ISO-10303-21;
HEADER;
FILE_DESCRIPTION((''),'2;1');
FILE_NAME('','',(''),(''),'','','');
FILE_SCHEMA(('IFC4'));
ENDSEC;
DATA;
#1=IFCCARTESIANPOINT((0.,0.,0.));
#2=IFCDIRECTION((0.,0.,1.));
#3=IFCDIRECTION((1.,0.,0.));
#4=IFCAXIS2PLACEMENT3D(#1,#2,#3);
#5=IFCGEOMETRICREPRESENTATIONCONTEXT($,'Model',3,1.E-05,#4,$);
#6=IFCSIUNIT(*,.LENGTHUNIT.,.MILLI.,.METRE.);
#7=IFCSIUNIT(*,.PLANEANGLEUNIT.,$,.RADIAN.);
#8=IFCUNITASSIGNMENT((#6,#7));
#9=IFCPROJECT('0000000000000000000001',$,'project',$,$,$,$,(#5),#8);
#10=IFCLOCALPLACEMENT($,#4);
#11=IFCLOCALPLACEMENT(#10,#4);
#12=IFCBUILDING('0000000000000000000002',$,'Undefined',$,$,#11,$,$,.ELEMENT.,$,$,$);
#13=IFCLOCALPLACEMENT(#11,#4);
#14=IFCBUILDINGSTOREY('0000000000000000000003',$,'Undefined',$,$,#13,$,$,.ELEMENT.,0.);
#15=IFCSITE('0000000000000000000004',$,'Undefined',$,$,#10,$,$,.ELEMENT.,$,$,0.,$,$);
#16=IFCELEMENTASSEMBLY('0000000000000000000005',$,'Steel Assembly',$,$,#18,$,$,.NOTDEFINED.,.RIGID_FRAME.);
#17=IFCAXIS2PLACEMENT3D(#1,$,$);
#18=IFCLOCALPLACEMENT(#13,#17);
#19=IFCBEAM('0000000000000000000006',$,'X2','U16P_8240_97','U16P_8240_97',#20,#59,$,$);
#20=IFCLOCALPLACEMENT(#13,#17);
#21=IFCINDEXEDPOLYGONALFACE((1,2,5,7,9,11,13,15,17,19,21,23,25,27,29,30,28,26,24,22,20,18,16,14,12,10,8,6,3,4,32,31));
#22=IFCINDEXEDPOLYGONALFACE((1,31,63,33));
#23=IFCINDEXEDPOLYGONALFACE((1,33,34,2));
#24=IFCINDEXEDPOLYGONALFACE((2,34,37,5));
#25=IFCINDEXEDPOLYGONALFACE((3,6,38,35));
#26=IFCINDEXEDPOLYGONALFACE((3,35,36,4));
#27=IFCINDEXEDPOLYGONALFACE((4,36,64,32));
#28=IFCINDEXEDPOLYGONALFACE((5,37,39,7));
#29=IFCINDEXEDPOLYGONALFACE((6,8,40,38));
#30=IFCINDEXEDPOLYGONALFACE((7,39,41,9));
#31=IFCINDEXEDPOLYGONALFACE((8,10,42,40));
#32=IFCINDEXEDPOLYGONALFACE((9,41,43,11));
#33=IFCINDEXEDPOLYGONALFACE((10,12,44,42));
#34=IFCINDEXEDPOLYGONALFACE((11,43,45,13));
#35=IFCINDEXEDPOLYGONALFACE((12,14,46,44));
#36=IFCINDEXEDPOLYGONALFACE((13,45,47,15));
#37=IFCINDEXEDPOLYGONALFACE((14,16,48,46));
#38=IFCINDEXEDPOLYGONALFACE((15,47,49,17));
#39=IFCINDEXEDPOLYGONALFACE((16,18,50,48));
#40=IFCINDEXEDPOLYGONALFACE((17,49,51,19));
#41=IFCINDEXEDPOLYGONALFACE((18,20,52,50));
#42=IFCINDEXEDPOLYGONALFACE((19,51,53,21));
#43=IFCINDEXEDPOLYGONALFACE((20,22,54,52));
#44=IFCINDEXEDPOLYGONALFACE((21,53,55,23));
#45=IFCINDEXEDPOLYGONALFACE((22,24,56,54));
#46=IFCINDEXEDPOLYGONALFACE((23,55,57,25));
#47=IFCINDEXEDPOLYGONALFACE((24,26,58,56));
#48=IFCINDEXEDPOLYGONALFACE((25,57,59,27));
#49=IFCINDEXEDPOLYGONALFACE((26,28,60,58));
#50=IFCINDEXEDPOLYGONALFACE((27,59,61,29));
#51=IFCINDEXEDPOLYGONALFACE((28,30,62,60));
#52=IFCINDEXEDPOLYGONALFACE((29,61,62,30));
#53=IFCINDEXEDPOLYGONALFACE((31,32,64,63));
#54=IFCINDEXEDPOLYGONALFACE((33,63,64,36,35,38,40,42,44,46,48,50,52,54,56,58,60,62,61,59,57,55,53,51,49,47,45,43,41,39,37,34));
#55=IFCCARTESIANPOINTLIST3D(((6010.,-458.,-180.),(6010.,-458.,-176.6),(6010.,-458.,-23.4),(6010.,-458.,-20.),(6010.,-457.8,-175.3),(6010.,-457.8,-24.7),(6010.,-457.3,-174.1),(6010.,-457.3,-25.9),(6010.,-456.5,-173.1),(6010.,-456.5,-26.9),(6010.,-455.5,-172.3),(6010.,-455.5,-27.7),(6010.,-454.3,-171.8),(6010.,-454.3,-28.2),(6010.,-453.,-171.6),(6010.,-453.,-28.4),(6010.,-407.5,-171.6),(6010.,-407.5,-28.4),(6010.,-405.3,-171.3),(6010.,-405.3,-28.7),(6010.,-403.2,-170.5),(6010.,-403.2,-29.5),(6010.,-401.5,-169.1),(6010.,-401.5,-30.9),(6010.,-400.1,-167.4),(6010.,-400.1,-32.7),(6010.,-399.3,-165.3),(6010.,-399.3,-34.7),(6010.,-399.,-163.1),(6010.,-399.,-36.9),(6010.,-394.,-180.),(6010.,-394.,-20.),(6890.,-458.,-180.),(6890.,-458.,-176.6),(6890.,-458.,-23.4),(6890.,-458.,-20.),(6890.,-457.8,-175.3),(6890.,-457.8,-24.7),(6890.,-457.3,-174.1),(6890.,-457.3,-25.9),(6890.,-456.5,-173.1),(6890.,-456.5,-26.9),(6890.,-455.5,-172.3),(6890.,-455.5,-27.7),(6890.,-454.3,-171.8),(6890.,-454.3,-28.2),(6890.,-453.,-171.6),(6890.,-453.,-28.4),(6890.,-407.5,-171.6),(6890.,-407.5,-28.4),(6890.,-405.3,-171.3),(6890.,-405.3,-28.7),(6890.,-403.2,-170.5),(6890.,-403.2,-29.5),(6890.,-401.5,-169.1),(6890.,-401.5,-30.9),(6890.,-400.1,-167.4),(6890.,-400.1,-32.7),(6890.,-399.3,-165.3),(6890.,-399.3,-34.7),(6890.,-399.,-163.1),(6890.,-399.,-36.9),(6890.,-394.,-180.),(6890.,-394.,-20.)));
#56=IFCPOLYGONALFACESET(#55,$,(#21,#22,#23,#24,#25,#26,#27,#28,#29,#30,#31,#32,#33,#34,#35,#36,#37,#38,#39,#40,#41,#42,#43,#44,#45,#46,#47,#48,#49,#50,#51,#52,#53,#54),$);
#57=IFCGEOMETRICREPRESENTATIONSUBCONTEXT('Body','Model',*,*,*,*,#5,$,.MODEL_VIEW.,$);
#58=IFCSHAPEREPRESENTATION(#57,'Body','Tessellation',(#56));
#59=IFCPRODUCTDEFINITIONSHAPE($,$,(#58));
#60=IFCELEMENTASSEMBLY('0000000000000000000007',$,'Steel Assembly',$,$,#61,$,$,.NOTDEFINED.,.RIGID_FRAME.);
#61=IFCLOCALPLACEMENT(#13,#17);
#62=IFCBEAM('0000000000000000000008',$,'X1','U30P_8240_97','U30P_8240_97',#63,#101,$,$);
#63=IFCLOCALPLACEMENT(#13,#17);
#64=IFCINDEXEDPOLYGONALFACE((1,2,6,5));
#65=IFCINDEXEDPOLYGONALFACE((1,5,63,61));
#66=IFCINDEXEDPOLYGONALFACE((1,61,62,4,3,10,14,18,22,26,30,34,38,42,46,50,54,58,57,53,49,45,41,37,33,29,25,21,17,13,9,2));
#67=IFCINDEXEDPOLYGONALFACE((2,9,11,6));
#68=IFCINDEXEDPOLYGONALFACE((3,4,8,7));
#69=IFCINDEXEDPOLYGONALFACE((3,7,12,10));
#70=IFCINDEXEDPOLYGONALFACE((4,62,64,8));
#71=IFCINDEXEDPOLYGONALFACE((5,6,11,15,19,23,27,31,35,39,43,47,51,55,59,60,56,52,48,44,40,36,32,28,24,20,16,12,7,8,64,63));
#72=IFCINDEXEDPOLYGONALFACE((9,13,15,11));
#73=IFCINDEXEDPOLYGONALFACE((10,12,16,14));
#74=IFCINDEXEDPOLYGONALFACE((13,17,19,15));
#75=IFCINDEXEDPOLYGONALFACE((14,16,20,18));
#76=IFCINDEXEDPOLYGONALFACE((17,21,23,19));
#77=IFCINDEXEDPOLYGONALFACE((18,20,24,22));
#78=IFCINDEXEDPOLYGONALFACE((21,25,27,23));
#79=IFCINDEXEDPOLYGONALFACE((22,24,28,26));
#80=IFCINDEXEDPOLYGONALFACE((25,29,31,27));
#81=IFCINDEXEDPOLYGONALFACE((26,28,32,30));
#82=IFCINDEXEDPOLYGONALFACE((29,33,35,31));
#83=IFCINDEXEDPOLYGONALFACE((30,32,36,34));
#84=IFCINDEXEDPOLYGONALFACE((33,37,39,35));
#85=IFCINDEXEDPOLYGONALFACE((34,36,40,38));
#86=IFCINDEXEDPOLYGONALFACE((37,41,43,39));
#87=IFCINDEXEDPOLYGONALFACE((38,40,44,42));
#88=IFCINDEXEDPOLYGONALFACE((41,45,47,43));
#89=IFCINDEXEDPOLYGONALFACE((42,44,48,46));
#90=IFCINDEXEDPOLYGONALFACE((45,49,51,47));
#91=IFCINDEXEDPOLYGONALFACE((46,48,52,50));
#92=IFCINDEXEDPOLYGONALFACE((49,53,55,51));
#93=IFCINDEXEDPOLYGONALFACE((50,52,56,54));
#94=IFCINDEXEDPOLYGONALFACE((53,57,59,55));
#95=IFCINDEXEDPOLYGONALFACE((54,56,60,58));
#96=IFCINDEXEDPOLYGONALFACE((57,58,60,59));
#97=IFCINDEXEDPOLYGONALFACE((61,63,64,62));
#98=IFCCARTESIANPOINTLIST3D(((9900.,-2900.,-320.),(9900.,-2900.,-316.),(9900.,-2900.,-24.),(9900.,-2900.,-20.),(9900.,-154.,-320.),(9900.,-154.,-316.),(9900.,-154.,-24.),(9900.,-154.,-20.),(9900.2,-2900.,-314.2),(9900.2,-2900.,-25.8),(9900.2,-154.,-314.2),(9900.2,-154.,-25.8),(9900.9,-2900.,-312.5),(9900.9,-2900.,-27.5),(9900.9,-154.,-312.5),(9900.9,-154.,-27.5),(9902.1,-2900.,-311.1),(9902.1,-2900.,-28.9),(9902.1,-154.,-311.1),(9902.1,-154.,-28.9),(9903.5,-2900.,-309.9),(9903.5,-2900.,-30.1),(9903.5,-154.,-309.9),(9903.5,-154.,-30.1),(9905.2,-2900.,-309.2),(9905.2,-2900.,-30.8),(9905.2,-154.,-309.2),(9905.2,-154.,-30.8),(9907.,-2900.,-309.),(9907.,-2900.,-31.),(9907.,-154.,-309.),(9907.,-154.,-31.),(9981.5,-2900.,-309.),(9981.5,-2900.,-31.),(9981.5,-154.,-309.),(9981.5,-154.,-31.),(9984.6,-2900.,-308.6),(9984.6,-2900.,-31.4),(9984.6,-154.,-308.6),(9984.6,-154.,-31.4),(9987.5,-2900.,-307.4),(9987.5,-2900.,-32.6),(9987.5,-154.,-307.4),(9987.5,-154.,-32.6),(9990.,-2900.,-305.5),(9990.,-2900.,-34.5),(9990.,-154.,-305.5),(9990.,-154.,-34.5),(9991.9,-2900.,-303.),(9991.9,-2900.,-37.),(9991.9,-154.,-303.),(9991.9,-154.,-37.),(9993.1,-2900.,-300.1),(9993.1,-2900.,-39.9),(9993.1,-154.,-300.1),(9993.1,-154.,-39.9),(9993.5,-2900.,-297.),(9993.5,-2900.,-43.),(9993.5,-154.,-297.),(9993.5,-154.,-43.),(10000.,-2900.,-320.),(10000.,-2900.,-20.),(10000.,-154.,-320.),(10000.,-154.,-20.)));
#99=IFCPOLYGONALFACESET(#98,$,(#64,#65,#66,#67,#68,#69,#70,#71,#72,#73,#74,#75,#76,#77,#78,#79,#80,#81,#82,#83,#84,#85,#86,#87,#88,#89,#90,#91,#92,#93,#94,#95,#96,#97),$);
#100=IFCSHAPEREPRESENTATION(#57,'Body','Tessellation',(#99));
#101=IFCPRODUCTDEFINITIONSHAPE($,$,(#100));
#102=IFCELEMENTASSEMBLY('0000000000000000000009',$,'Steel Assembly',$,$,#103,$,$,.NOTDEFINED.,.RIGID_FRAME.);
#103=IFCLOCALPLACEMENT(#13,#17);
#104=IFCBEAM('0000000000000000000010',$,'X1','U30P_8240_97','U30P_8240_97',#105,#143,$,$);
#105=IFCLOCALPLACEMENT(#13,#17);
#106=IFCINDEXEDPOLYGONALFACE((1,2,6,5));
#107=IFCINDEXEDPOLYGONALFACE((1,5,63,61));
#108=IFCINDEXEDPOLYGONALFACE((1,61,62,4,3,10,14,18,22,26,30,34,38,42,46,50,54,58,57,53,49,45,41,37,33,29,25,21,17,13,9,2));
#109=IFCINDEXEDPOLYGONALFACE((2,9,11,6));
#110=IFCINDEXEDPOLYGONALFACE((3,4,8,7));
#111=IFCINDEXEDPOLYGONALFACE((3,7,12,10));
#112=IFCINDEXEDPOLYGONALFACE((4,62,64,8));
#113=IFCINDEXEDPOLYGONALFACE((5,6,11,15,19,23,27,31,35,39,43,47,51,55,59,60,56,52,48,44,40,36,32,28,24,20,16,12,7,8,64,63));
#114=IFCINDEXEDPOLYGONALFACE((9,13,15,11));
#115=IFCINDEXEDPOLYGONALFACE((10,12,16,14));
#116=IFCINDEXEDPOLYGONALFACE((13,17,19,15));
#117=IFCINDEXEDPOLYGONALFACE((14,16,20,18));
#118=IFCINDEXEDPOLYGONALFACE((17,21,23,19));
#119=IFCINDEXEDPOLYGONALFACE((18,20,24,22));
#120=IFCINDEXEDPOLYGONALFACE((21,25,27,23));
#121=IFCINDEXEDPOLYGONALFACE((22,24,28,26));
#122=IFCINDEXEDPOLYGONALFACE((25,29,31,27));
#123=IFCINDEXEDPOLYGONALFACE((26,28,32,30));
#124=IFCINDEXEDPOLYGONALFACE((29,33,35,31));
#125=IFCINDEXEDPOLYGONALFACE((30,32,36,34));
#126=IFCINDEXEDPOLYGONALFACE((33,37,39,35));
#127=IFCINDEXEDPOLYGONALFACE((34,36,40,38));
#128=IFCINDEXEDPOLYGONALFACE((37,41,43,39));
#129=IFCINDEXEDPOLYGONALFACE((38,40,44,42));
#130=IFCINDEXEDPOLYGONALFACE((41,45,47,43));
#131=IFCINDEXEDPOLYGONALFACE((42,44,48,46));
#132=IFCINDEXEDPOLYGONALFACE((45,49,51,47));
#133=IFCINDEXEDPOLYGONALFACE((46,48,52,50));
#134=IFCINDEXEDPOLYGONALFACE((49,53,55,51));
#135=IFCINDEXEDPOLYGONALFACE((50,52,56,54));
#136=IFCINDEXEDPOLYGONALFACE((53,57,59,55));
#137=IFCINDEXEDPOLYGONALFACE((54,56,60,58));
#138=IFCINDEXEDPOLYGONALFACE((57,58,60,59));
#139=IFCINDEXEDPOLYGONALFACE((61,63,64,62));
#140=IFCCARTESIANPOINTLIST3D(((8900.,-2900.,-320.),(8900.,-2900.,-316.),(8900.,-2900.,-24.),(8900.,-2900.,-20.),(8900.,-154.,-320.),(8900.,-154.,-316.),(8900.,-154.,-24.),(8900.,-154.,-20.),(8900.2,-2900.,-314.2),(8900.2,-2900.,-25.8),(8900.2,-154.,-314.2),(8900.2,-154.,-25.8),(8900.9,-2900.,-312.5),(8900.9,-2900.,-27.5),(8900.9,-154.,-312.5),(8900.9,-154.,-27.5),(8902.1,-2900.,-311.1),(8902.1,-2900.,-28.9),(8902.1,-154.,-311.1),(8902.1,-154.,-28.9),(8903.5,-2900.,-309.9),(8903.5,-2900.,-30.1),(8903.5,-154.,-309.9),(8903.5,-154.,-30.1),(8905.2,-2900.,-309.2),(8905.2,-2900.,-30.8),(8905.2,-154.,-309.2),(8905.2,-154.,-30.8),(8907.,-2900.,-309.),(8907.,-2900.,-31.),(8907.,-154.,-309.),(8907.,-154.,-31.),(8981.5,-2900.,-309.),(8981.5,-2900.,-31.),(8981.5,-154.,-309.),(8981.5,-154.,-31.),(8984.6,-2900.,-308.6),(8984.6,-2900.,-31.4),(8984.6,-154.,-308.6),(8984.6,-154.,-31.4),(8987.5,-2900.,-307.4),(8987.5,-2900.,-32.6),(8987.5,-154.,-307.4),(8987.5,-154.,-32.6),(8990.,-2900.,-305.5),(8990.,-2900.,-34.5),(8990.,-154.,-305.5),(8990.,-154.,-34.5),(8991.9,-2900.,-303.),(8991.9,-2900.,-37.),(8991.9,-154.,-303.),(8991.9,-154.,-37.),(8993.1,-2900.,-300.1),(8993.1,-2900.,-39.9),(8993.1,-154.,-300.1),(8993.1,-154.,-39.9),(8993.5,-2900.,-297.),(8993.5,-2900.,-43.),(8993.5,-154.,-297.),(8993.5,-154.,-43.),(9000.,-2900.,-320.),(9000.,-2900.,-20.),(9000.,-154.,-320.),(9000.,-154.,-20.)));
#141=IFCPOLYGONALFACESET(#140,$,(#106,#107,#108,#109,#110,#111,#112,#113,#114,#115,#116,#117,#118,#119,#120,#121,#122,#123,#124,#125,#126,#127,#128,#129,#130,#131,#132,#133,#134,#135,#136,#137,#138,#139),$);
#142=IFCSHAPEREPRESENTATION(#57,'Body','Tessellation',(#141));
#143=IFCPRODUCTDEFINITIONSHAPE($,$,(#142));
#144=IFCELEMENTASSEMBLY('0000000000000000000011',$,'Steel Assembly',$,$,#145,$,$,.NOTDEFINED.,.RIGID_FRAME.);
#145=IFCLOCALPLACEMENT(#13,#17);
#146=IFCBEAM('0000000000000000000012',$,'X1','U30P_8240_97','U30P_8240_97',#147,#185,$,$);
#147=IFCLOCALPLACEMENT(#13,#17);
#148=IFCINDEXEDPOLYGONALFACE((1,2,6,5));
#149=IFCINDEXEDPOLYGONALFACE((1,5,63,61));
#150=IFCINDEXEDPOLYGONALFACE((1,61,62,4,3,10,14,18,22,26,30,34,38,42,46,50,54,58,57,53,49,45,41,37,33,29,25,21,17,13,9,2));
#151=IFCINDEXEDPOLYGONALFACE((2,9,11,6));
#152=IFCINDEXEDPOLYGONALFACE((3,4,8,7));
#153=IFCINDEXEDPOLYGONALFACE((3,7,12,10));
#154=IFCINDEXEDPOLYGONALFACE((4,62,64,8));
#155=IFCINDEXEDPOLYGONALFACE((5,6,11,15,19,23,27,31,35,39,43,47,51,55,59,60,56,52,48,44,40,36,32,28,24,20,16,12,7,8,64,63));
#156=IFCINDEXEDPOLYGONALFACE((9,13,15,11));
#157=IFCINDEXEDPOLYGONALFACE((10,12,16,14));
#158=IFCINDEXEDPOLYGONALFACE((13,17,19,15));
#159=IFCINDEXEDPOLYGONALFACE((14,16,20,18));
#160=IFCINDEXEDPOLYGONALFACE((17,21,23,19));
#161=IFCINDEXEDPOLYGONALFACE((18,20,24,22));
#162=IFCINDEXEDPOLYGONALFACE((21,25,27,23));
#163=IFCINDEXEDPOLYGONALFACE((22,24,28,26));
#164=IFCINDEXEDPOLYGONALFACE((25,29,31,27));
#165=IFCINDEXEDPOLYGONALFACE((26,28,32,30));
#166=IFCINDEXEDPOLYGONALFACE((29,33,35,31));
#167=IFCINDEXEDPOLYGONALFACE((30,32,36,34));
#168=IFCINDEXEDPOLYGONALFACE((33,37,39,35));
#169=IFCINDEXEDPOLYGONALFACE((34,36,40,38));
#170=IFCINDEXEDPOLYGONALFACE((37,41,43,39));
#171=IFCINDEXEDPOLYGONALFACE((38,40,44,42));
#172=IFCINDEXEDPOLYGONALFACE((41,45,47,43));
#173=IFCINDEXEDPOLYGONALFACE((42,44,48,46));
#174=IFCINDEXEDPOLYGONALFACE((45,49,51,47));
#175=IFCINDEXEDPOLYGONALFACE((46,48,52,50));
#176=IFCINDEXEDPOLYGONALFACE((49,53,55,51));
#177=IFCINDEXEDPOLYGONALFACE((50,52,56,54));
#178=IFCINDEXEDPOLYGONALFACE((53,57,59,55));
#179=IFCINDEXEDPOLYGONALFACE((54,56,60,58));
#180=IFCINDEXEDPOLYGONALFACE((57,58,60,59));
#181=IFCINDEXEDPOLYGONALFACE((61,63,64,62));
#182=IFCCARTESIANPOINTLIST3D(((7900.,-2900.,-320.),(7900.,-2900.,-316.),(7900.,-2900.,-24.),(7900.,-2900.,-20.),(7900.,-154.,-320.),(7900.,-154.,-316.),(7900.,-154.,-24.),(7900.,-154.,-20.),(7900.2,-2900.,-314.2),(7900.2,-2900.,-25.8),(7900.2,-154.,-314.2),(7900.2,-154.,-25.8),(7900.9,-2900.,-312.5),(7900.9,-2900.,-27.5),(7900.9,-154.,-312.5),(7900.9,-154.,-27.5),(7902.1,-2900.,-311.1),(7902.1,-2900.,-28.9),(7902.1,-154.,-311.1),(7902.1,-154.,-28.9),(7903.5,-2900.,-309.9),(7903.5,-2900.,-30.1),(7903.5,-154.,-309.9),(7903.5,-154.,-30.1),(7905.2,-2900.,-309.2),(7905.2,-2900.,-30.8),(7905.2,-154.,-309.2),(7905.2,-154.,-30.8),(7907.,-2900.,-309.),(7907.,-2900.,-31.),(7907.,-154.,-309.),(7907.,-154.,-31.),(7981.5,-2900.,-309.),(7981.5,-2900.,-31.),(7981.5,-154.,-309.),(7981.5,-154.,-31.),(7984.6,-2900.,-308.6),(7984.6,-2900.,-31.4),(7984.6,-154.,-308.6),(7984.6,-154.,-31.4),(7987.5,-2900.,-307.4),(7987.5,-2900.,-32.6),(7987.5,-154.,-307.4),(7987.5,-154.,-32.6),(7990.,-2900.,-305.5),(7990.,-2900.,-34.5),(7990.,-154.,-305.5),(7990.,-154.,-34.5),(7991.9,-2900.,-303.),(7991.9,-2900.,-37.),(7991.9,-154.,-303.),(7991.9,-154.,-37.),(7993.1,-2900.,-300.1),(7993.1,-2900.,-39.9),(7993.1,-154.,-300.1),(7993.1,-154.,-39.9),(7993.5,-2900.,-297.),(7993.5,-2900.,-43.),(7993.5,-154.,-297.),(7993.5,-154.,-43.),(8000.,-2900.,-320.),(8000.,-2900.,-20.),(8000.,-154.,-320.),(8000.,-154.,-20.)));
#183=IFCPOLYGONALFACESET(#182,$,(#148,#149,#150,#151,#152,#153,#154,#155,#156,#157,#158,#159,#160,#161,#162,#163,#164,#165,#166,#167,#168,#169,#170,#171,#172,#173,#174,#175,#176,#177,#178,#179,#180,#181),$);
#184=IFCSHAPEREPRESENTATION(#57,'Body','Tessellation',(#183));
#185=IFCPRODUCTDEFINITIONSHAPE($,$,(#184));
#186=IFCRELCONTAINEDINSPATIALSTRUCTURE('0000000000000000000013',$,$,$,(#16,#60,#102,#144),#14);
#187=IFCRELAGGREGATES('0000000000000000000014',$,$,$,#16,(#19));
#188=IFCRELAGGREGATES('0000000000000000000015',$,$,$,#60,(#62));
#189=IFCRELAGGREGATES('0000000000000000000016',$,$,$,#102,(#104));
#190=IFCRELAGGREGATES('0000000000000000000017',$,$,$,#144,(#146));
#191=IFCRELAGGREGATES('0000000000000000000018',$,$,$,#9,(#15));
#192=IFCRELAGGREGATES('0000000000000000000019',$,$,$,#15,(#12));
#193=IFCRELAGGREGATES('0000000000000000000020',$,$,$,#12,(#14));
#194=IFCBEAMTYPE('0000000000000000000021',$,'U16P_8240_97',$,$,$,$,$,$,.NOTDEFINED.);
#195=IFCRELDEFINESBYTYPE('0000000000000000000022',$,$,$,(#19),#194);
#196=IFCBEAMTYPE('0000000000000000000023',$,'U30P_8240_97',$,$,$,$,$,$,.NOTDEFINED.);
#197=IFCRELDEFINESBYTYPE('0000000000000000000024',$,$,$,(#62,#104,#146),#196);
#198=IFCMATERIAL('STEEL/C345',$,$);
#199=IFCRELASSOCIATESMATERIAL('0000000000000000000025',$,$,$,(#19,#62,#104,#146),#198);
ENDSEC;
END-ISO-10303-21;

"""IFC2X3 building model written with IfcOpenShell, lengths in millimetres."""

from ifc_helpers import new_model, si_unit, frame, origin_with_axes, origin_2d_with_axis, place, context, subcontext, project, spatial, u_section, extrude, material, type_object, element, aggregate, save


model = new_model("IFC2X3")

# Units and contexts
model_context = context("Model", 3, precision=1e-05, world=origin_with_axes())
body_context = subcontext(model_context, "Body", "Model", "MODEL_VIEW")
ifc_project = project(units=[si_unit("LENGTHUNIT", "METRE", prefix="MILLI"), si_unit("PLANEANGLEUNIT", "RADIAN")], contexts=[model_context])

# Site, building, storey
site_placement = place(None, origin_with_axes())
site = spatial("IfcSite", under=ifc_project, at=site_placement, Name="Undefined", CompositionType="ELEMENT", RefElevation=0.0)
building_placement = place(site_placement, origin_with_axes())
building = spatial("IfcBuilding", under=site, at=building_placement, Name="Undefined", CompositionType="ELEMENT")
storey_placement = place(building_placement, origin_with_axes())
storey = spatial("IfcBuildingStorey", under=building, at=storey_placement, Name="Undefined", CompositionType="ELEMENT", Elevation=0.0)

# Shared definitions
ifc_material_1 = material(Name="STEEL/C345")

# Element assemblies, beams
beam_type_1 = type_object("IfcBeamType", Name="U16P_8240_97", PredefinedType="NOTDEFINED")
assembly_1_placement = place(storey_placement, origin_with_axes())
assembly_1 = element("IfcElementAssembly", 1, at=assembly_1_placement, inside=storey, Name="Steel Assembly", AssemblyPlace="NOTDEFINED", PredefinedType="RIGID_FRAME")
beam_1_placement = place(assembly_1_placement, frame((6890.0, -426.0, -100.0), z_axis=(0.0, 0.0, -1.0), x_axis=(-1.0, 0.0, 0.0)))
beam_1 = element("IfcBeam", 2, at=beam_1_placement, type_object=beam_type_1, material=ifc_material_1, Name="X2", Description="U16P_8240_97", ObjectType="U16P_8240_97", context=body_context, shape_type="SweptSolid", body=[
    extrude(u_section(Depth=160.0, FlangeWidth=64.0, WebThickness=5.0, FlangeThickness=8.4, FilletRadius=8.5, EdgeRadius=5.0, at=origin_2d_with_axis()), frame((880.0, 0.0, 0.0), z_axis=(-1.0, 0.0, 0.0), x_axis=(0.0, -1.0, 0.0)), (0.0, 0.0, 1.0), 880.0),
])
aggregate(assembly_1, [beam_1])
assembly_2_placement = place(storey_placement, origin_with_axes())
assembly_2 = element("IfcElementAssembly", 3, at=assembly_2_placement, inside=storey, Name="Steel Assembly", AssemblyPlace="NOTDEFINED", PredefinedType="RIGID_FRAME")
beam_type_2 = type_object("IfcBeamType", Name="U30P_8240_97", PredefinedType="NOTDEFINED")
beam_2_placement = place(assembly_2_placement, frame((9950.0, -154.0, -170.0), z_axis=(0.0, 0.0, 1.0), x_axis=(0.0, -1.0, 0.0)))
beam_2 = element("IfcBeam", 4, at=beam_2_placement, type_object=beam_type_2, material=ifc_material_1, Name="X1", Description="U30P_8240_97", ObjectType="U30P_8240_97", context=body_context, shape_type="SweptSolid", body=[
    extrude(u_section(Depth=300.0, FlangeWidth=100.0, WebThickness=6.5, FlangeThickness=11.0, FilletRadius=12.0, EdgeRadius=7.0, at=origin_2d_with_axis()), frame((2746.0, 0.0, 0.0), z_axis=(-1.0, 0.0, 0.0), x_axis=(0.0, -1.0, 0.0)), (0.0, 0.0, 1.0), 2746.0),
])
aggregate(assembly_2, [beam_2])
assembly_3_placement = place(storey_placement, origin_with_axes())
assembly_3 = element("IfcElementAssembly", 5, at=assembly_3_placement, inside=storey, Name="Steel Assembly", AssemblyPlace="NOTDEFINED", PredefinedType="RIGID_FRAME")
beam_3_placement = place(assembly_3_placement, frame((8950.0, -154.0, -170.0), z_axis=(0.0, 0.0, 1.0), x_axis=(0.0, -1.0, 0.0)))
beam_3 = element("IfcBeam", 6, at=beam_3_placement, type_object=beam_type_2, material=ifc_material_1, Name="X1", Description="U30P_8240_97", ObjectType="U30P_8240_97", context=body_context, shape_type="SweptSolid", body=[
    extrude(u_section(Depth=300.0, FlangeWidth=100.0, WebThickness=6.5, FlangeThickness=11.0, FilletRadius=12.0, EdgeRadius=7.0, at=origin_2d_with_axis()), frame((2746.0, 0.0, 0.0), z_axis=(-1.0, 0.0, 0.0), x_axis=(0.0, -1.0, 0.0)), (0.0, 0.0, 1.0), 2746.0),
])
aggregate(assembly_3, [beam_3])
assembly_4_placement = place(storey_placement, origin_with_axes())
assembly_4 = element("IfcElementAssembly", 7, at=assembly_4_placement, inside=storey, Name="Steel Assembly", AssemblyPlace="NOTDEFINED", PredefinedType="RIGID_FRAME")
beam_4_placement = place(assembly_4_placement, frame((7950.0, -154.0, -170.0), z_axis=(0.0, 0.0, 1.0), x_axis=(0.0, -1.0, 0.0)))
beam_4 = element("IfcBeam", 8, at=beam_4_placement, type_object=beam_type_2, material=ifc_material_1, Name="X1", Description="U30P_8240_97", ObjectType="U30P_8240_97", context=body_context, shape_type="SweptSolid", body=[
    extrude(u_section(Depth=300.0, FlangeWidth=100.0, WebThickness=6.5, FlangeThickness=11.0, FilletRadius=12.0, EdgeRadius=7.0, at=origin_2d_with_axis()), frame((2746.0, 0.0, 0.0), z_axis=(-1.0, 0.0, 0.0), x_axis=(0.0, -1.0, 0.0)), (0.0, 0.0, 1.0), 2746.0),
])
aggregate(assembly_4, [beam_4])

save(model, "model.ifc")
